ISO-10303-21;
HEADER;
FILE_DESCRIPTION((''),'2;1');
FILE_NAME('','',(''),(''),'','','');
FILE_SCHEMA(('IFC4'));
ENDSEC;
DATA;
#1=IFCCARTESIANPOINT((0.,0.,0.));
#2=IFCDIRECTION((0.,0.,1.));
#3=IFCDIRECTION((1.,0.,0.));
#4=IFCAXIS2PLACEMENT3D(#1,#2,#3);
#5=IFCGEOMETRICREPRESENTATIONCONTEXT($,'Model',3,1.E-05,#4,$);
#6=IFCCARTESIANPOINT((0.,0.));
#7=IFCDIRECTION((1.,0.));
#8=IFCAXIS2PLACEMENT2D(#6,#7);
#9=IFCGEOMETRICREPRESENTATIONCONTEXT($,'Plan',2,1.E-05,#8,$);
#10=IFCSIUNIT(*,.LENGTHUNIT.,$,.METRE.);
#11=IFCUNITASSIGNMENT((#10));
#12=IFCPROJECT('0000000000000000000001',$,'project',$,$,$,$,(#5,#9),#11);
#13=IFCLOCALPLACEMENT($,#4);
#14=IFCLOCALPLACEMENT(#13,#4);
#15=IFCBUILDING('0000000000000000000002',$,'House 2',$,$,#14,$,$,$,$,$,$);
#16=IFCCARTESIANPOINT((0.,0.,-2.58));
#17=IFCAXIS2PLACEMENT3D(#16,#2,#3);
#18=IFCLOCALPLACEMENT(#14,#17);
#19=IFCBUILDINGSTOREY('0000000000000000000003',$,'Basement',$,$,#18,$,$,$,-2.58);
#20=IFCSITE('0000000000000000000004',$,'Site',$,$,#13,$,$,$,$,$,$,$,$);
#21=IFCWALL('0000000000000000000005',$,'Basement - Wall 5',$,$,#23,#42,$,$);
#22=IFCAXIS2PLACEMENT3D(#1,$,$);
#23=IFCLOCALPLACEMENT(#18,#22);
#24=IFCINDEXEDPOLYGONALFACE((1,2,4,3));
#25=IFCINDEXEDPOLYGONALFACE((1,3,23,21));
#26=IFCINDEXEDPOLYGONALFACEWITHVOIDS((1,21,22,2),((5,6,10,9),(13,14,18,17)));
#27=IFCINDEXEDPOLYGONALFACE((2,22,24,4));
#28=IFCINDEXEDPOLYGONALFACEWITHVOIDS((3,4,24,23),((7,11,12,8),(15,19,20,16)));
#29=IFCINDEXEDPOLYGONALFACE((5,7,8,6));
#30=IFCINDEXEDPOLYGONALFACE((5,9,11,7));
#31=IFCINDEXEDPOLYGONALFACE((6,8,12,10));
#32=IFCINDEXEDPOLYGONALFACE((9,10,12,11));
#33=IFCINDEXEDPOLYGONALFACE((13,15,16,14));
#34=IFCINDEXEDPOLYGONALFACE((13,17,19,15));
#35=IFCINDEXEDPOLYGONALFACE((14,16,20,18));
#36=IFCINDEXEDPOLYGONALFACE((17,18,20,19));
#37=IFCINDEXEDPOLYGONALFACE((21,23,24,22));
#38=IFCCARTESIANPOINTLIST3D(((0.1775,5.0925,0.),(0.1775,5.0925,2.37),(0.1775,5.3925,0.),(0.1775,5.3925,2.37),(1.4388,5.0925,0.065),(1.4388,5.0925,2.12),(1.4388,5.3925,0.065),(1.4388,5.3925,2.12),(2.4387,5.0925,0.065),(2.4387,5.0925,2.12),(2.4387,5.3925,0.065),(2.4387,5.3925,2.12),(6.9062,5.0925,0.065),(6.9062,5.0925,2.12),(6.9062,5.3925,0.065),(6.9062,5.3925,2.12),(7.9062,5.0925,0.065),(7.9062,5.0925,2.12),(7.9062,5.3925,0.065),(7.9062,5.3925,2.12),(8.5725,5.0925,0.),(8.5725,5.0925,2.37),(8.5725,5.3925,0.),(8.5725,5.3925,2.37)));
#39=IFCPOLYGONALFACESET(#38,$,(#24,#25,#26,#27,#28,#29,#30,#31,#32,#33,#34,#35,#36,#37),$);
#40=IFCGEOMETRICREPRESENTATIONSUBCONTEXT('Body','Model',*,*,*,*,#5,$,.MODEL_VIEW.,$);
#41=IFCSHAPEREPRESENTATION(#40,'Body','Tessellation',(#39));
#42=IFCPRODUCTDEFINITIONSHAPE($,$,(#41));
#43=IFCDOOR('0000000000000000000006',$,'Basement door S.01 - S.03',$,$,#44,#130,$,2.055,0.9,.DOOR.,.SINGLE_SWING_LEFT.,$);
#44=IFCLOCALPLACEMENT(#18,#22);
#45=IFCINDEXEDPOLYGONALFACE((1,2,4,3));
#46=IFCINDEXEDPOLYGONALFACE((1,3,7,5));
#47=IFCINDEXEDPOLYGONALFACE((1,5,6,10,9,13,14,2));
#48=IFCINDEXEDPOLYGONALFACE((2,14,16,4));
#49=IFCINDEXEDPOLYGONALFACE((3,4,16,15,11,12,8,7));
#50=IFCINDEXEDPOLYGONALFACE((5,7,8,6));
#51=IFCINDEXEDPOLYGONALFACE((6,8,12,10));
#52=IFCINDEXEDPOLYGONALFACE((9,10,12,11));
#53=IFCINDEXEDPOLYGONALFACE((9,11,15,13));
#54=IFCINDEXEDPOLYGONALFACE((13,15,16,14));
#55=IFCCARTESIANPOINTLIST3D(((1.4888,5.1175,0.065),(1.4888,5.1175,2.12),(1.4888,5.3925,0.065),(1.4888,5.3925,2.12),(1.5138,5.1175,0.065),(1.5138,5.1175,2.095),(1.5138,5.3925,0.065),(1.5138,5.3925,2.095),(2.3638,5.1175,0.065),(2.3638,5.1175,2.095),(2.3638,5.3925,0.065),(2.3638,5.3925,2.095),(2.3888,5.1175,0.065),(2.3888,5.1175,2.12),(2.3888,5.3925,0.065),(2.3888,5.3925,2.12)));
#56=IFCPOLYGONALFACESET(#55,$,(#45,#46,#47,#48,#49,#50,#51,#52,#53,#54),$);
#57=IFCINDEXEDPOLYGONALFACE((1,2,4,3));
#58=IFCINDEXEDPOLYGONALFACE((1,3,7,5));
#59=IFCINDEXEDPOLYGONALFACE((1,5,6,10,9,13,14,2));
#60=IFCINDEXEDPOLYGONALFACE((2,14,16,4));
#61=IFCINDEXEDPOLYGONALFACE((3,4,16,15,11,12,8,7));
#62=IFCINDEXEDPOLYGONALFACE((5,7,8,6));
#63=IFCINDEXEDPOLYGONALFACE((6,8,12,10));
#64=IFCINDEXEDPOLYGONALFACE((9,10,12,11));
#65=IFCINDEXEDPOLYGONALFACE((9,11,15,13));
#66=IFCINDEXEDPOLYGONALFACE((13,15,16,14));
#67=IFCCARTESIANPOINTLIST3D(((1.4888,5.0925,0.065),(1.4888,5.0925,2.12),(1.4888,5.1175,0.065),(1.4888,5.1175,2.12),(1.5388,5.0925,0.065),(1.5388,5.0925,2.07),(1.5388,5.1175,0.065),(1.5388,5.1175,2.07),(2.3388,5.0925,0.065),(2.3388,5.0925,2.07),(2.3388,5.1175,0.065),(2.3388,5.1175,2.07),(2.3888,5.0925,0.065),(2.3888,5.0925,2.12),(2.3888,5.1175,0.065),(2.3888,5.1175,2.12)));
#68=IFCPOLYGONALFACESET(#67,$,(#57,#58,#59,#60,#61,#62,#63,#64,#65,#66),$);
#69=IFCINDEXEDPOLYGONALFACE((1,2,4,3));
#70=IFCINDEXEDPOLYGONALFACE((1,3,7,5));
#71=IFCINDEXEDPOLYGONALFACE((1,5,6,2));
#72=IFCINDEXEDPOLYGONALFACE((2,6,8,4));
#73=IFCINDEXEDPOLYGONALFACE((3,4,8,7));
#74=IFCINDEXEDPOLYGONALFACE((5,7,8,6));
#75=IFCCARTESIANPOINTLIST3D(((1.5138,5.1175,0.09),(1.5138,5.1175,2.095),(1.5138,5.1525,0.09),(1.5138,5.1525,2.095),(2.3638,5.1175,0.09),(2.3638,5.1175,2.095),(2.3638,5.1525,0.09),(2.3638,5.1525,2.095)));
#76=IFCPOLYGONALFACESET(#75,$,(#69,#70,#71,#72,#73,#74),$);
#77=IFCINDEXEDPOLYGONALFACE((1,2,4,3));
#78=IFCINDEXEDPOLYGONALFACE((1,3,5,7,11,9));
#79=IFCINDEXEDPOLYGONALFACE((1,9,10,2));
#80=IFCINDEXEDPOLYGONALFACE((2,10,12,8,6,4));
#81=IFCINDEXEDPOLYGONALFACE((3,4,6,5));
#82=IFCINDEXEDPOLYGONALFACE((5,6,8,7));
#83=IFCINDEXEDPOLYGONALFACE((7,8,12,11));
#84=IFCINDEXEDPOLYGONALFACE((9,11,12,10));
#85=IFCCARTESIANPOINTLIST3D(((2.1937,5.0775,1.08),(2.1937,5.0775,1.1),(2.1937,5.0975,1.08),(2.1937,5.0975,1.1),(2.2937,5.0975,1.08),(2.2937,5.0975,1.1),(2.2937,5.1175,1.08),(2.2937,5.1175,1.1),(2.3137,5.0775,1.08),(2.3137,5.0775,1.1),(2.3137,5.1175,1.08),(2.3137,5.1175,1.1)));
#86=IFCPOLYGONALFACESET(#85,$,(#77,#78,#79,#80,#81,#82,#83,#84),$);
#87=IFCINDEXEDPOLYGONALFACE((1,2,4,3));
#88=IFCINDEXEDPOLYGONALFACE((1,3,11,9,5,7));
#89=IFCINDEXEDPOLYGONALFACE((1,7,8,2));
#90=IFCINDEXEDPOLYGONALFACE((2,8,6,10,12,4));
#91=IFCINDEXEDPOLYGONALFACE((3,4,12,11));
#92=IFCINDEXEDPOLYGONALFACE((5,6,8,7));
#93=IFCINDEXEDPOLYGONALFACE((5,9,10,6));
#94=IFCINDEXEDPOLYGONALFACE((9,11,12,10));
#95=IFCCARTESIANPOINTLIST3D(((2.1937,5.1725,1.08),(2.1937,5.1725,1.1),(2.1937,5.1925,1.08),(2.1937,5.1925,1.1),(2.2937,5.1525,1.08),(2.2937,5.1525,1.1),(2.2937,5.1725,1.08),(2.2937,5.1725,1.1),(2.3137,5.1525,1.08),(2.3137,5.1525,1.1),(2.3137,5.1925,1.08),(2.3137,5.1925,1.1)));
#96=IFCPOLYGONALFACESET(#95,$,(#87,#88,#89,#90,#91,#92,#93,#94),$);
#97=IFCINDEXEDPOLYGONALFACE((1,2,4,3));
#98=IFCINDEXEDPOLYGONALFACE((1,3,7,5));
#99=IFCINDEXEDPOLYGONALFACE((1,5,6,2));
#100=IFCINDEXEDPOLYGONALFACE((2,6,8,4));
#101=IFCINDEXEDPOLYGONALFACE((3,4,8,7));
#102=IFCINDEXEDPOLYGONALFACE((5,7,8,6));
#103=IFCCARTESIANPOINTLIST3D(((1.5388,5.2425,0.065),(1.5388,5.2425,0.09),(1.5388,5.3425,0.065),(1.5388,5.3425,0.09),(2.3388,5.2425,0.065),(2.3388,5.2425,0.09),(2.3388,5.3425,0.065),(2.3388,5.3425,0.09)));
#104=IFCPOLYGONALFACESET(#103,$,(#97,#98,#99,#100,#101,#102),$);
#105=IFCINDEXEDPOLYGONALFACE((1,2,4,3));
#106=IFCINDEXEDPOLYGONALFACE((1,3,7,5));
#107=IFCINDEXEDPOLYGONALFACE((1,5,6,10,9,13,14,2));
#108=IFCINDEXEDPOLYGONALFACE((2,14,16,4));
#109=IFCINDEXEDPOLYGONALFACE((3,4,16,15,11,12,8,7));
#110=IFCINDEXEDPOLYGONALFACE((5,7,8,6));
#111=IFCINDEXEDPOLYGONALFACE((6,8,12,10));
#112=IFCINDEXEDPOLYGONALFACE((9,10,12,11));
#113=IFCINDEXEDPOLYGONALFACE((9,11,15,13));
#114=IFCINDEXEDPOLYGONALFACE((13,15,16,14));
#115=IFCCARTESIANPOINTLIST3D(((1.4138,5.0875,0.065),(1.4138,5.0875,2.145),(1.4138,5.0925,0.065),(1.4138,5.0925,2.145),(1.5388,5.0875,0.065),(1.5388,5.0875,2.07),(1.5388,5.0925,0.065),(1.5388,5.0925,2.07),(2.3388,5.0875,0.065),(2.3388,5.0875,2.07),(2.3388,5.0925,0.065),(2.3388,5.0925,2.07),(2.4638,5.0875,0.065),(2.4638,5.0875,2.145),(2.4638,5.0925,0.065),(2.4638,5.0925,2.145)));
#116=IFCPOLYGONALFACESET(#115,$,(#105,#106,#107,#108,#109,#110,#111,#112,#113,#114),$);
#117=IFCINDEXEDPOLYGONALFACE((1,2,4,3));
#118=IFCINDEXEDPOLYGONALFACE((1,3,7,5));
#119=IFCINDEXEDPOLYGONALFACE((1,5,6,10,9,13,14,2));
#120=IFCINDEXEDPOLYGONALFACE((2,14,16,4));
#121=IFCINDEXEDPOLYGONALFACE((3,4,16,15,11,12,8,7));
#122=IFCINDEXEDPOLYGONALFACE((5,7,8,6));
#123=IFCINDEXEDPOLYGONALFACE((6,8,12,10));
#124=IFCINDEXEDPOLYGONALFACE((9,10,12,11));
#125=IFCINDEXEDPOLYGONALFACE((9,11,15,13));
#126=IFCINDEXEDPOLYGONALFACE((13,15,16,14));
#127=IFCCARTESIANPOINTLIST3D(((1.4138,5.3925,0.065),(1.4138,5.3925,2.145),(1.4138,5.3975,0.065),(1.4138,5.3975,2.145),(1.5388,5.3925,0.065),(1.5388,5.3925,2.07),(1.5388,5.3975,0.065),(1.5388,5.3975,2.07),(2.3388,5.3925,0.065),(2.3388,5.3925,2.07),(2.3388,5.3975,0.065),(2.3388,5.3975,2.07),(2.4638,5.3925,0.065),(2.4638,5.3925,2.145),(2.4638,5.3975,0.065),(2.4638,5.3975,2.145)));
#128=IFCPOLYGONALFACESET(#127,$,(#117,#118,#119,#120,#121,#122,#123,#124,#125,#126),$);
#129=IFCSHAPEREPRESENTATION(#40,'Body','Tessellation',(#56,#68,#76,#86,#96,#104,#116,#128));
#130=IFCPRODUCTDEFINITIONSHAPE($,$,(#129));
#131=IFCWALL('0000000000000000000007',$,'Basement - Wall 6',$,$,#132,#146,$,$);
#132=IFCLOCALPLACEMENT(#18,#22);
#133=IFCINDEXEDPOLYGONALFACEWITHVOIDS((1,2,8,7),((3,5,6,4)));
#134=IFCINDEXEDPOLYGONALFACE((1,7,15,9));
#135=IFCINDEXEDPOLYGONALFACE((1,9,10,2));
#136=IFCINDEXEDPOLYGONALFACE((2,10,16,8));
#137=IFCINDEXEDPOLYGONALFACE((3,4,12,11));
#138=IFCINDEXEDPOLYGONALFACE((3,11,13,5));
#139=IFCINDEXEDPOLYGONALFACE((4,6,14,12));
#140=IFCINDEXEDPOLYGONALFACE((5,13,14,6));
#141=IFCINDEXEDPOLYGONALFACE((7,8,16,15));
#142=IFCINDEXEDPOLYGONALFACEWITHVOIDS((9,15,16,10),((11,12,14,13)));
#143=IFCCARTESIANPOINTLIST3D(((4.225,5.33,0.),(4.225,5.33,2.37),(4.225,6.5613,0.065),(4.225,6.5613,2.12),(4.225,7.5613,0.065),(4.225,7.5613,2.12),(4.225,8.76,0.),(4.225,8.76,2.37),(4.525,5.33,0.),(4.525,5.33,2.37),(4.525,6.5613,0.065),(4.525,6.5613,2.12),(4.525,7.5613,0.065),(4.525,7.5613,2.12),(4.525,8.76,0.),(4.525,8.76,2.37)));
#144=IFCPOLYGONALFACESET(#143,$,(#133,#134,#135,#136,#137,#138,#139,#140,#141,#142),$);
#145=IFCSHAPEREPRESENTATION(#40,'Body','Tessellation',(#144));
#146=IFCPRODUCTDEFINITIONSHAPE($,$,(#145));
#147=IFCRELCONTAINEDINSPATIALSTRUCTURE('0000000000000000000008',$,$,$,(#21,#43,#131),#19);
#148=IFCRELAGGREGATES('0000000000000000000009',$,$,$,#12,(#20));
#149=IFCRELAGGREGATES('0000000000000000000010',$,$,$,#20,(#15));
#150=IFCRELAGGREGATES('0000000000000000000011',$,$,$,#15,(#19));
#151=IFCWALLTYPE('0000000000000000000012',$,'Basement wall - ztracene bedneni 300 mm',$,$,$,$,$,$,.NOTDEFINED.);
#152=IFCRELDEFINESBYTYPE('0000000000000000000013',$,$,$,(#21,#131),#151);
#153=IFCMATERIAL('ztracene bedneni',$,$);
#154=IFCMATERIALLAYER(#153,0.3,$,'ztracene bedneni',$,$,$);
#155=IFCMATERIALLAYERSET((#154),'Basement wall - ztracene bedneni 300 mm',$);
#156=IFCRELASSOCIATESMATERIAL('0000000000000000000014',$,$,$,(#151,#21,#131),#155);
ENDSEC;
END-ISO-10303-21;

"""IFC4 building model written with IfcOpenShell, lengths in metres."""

from ifc_helpers import new_model, entity, si_unit, frame, origin_with_axes, origin_2d_with_axis, place, context, subcontext, project, spatial, line, indexed_curve, outline, extrude, shape, source, transform, mapped, material, layer, layer_set, layer_usage, type_object, element, fill, save


model = new_model("IFC4")

# Units and contexts
model_context = context("Model", 3, precision=1e-05, world=origin_with_axes())
plan_context = context("Plan", 2, precision=1e-05, world=origin_2d_with_axis())
body_context_1 = subcontext(model_context, "Body", "Model", "MODEL_VIEW")
body_context_2 = subcontext(plan_context, "Body", "Plan", "PLAN_VIEW")
ifc_project = project(units=[si_unit("LENGTHUNIT", "METRE")], contexts=[model_context, plan_context])

# Site, building, storey
site_placement = place(None, origin_with_axes())
site = spatial("IfcSite", under=ifc_project, at=site_placement, Name="Site")
building_placement = place(site_placement, origin_with_axes())
building = spatial("IfcBuilding", under=site, at=building_placement, Name="House 2")
storey_placement = place(building_placement, frame((0.0, 0.0, -2.58), z_axis=(0.0, 0.0, 1.0), x_axis=(1.0, 0.0, 0.0)))
storey = spatial("IfcBuildingStorey", under=building, at=storey_placement, Name="Basement", Elevation=-2.58)

# Shared definitions
ifc_material_1 = material(Name="ztracene bedneni")
ifc_layer = layer(ifc_material_1, 0.3, Name="ztracene bedneni")
ifc_layer_set = layer_set([ifc_layer], Name="Basement wall - ztracene bedneni 300 mm")
wall_type = type_object("IfcWallType", Name="Basement wall - ztracene bedneni 300 mm", PredefinedType="NOTDEFINED", material=ifc_layer_set)

# Wall, openings, door
ifc_layer_usage_1 = layer_usage(ifc_layer_set, "AXIS2", "NEGATIVE", 0.15)
wall_1_placement = place(storey_placement, frame((0.1775, 5.2425, 0.0), z_axis=(0.0, 0.0, 1.0), x_axis=(1.0, 0.0, 0.0)))
wall_1 = element("IfcWall", 1, at=wall_1_placement, inside=storey, type_object=wall_type, material=ifc_layer_usage_1, Name="Basement - Wall 5", context=body_context_1, shape_type="SweptSolid", body=[
    extrude(outline(indexed_curve([(0.0, 0.0), (0.0, 0.3), (8.395, 0.3), (8.395, 0.0), (0.0, 0.0)], self_intersect=False)), frame((0.0, -0.15, 0.0), z_axis=(0.0, 0.0, 1.0), x_axis=(1.0, 0.0, 0.0)), (0.0, 0.0, 1.0), 2.37),
])
opening_1_placement = place(wall_1_placement, frame((1.2612, 0.0, 0.065), z_axis=(0.0, 0.0, 1.0), x_axis=(1.0, 0.0, 0.0)))
opening_1 = element("IfcOpeningElement", 2, at=opening_1_placement, cuts=wall_1, PredefinedType="OPENING", context=body_context_1, shape_type="SweptSolid", body=[
    extrude(outline(indexed_curve([(0.0, 0.0), (0.0, 0.4), (1.0, 0.4), (1.0, 0.0), (0.0, 0.0)], self_intersect=False)), frame((0.0, -0.2, 0.0), z_axis=(0.0, 0.0, 1.0), x_axis=(1.0, 0.0, 0.0)), (0.0, 0.0, 1.0), 2.055),
])
opening_2_placement = place(wall_1_placement, frame((6.7287, 0.0, 0.065), z_axis=(0.0, 0.0, 1.0), x_axis=(1.0, 0.0, 0.0)))
element("IfcOpeningElement", 3, at=opening_2_placement, cuts=wall_1, PredefinedType="OPENING", context=body_context_1, shape_type="SweptSolid", body=[
    extrude(outline(indexed_curve([(0.0, 0.0), (0.0, 0.4), (1.0, 0.4), (1.0, 0.0), (0.0, 0.0)], self_intersect=False)), frame((0.0, -0.2, 0.0), z_axis=(0.0, 0.0, 1.0), x_axis=(1.0, 0.0, 0.0)), (0.0, 0.0, 1.0), 2.055),
])
shared_indexed_poly_curve_1 = entity("IfcIndexedPolyCurve", entity("IfcCartesianPointList2D", [[-0.075, 0.0], [-0.075, 2.08], [0.975, 2.08], [0.975, 0.0], [0.85, 0.0], [0.85, 2.005], [0.05, 2.005], [0.05, 0.0]]), [entity("IfcLineIndex", [1, 2, 3, 4, 5, 6, 7, 8, 1])])
shared_shape_1 = source(origin_with_axes(), body_context_2, "Body", "Curve2D", [
    entity("IfcIndexedPolyCurve", entity("IfcCartesianPointList2D", [[0.0, -0.15], [0.0, 0.15], [0.025, 0.15], [0.025, -0.125], [0.05, -0.125], [0.05, -0.15]]), [entity("IfcLineIndex", [1, 2, 3, 4, 5, 6, 1])]),
    entity("IfcIndexedPolyCurve", entity("IfcCartesianPointList2D", [[0.9, -0.15], [0.9, 0.15], [0.875, 0.15], [0.875, -0.125], [0.85, -0.125], [0.85, -0.15]]), [entity("IfcLineIndex", [1, 2, 3, 4, 5, 6, 1])]),
    entity("IfcTrimmedCurve", entity("IfcEllipse", entity("IfcAxis2Placement2D", entity("IfcCartesianPoint", [0.06, 0.15]), entity("IfcDirection", [1.0, 0.0])), 0.815, 0.85), [entity("IfcCartesianPoint", [0.875, 0.15])], [entity("IfcCartesianPoint", [0.06, 1.0])], True, "CARTESIAN"),
    entity("IfcIndexedPolyCurve", entity("IfcCartesianPointList2D", [[0.025, 0.15], [0.06, 0.15], [0.06, 1.0], [0.025, 1.0]]), [entity("IfcLineIndex", [1, 2, 3, 4, 1])]),
])
door_1_placement = place(opening_1_placement, frame((0.05, 0.0, 0.0), z_axis=(0.0, 0.0, 1.0), x_axis=(1.0, 0.0, 0.0)))
door_1 = element("IfcDoor", 4, at=door_1_placement, inside=storey, Name="Basement door S.01 - S.03", OperationType="SINGLE_SWING_LEFT", OverallHeight=2.055, OverallWidth=0.9, PredefinedType="DOOR", shapes=[
    shape(body_context_1, "Body", "SweptSolid", [extrude(outline(indexed_curve([(0.0, 0.0), (0.0, 2.055), (0.9, 2.055), (0.9, 0.0), (0.875, 0.0), (0.875, 2.03), (0.025, 2.03), (0.025, 0.0)], segments=[line(1, 2, 3, 4, 5, 6, 7, 8, 1)])), frame((0.0, -0.125, 0.0), z_axis=(0.0, -1.0, 0.0), x_axis=(1.0, 0.0, 0.0)), (0.0, 0.0, -1.0), 0.275), extrude(outline(indexed_curve([(0.0, 0.0), (0.0, 2.055), (0.9, 2.055), (0.9, 0.0), (0.85, 0.0), (0.85, 2.005), (0.05, 2.005), (0.05, 0.0)], segments=[line(1, 2, 3, 4, 5, 6, 7, 8, 1)])), frame((0.0, -0.15, 0.0), z_axis=(0.0, -1.0, 0.0), x_axis=(1.0, 0.0, 0.0)), (0.0, 0.0, -1.0), 0.025), extrude(outline(indexed_curve([(0.0, 0.0), (0.85, 0.0), (0.85, 0.035), (0.0, 0.035)], segments=[line(1, 2, 3, 4, 1)])), frame((0.025, -0.125, 0.025), z_axis=(0.0, 0.0, 1.0), x_axis=(1.0, 0.0, 0.0)), (0.0, 0.0, 1.0), 2.005), extrude(outline(indexed_curve([(0.0, 0.0), (0.0, -0.04), (-0.12, -0.04), (-0.12, -0.02), (-0.02, -0.02), (-0.02, 0.0)], segments=[line(1, 2, 3, 4, 5, 6, 1)])), frame((0.825, -0.125, 1.015), z_axis=(0.0, 0.0, 1.0), x_axis=(1.0, 0.0, 0.0)), (0.0, 0.0, 1.0), 0.02), extrude(outline(indexed_curve([(0.0, 0.0), (0.0, 0.04), (-0.12, 0.04), (-0.12, 0.02), (-0.02, 0.02), (-0.02, 0.0)], segments=[line(1, 2, 3, 4, 5, 6, 1)])), frame((0.825, -0.09, 1.015), z_axis=(0.0, 0.0, 1.0), x_axis=(1.0, 0.0, 0.0)), (0.0, 0.0, 1.0), 0.02), extrude(outline(indexed_curve([(0.0, 0.0), (0.8, 0.0), (0.8, 0.1), (0.0, 0.1)], segments=[line(1, 2, 3, 4, 1)])), frame((0.05, 0.0, 0.0), z_axis=(0.0, 0.0, 1.0), x_axis=(1.0, 0.0, 0.0)), (0.0, 0.0, 1.0), 0.025), entity("IfcExtrudedAreaSolid", entity("IfcArbitraryClosedProfileDef", "AREA", None, shared_indexed_poly_curve_1), entity("IfcAxis2Placement3D", entity("IfcCartesianPoint", [0.0, -0.155, 0.0]), entity("IfcDirection", [0.0, -1.0, 0.0]), entity("IfcDirection", [1.0, 0.0, 0.0])), entity("IfcDirection", [0.0, 0.0, -1.0]), 0.005), entity("IfcExtrudedAreaSolid", entity("IfcArbitraryClosedProfileDef", "AREA", None, shared_indexed_poly_curve_1), entity("IfcAxis2Placement3D", entity("IfcCartesianPoint", [0.0, 0.15, 0.0]), entity("IfcDirection", [0.0, -1.0, 0.0]), entity("IfcDirection", [1.0, 0.0, 0.0])), entity("IfcDirection", [0.0, 0.0, -1.0]), 0.005)]),
    shape(body_context_2, "Body", "MappedRepresentation", [mapped(shared_shape_1, transform((0.0, 0.0, 1.0), x_axis=(1.0, 0.0, 0.0), y_axis=(0.0, 1.0, 0.0), z_axis=(0.0, 0.0, 1.0), scale=1.0))]),
])
fill(opening_1, door_1)

# Wall, opening
ifc_layer_usage_2 = layer_usage(ifc_layer_set, "AXIS2", "NEGATIVE", 0.15)
wall_2_placement = place(storey_placement, frame((4.375, 5.33, 0.0), z_axis=(0.0, 0.0, 1.0), x_axis=(0.0, 1.0, 0.0)))
wall_2 = element("IfcWall", 5, at=wall_2_placement, inside=storey, type_object=wall_type, material=ifc_layer_usage_2, Name="Basement - Wall 6", context=body_context_1, shape_type="SweptSolid", body=[
    extrude(outline(indexed_curve([(0.0, 0.0), (0.0, 0.3), (3.43, 0.3), (3.43, 0.0), (0.0, 0.0)], self_intersect=False)), frame((0.0, -0.15, 0.0), z_axis=(0.0, 0.0, 1.0), x_axis=(1.0, 0.0, 0.0)), (0.0, 0.0, 1.0), 2.37),
])
opening_3_placement = place(wall_2_placement, frame((1.2313, 0.0, 0.065), z_axis=(0.0, 0.0, 1.0), x_axis=(1.0, 0.0, 0.0)))
element("IfcOpeningElement", 6, at=opening_3_placement, cuts=wall_2, PredefinedType="OPENING", context=body_context_1, shape_type="SweptSolid", body=[
    extrude(outline(indexed_curve([(0.0, 0.0), (0.0, 0.4), (1.0, 0.4), (1.0, 0.0), (0.0, 0.0)], self_intersect=False)), frame((0.0, -0.2, 0.0), z_axis=(0.0, 0.0, 1.0), x_axis=(1.0, 0.0, 0.0)), (0.0, 0.0, 1.0), 2.055),
])

save(model, "model.ifc")
